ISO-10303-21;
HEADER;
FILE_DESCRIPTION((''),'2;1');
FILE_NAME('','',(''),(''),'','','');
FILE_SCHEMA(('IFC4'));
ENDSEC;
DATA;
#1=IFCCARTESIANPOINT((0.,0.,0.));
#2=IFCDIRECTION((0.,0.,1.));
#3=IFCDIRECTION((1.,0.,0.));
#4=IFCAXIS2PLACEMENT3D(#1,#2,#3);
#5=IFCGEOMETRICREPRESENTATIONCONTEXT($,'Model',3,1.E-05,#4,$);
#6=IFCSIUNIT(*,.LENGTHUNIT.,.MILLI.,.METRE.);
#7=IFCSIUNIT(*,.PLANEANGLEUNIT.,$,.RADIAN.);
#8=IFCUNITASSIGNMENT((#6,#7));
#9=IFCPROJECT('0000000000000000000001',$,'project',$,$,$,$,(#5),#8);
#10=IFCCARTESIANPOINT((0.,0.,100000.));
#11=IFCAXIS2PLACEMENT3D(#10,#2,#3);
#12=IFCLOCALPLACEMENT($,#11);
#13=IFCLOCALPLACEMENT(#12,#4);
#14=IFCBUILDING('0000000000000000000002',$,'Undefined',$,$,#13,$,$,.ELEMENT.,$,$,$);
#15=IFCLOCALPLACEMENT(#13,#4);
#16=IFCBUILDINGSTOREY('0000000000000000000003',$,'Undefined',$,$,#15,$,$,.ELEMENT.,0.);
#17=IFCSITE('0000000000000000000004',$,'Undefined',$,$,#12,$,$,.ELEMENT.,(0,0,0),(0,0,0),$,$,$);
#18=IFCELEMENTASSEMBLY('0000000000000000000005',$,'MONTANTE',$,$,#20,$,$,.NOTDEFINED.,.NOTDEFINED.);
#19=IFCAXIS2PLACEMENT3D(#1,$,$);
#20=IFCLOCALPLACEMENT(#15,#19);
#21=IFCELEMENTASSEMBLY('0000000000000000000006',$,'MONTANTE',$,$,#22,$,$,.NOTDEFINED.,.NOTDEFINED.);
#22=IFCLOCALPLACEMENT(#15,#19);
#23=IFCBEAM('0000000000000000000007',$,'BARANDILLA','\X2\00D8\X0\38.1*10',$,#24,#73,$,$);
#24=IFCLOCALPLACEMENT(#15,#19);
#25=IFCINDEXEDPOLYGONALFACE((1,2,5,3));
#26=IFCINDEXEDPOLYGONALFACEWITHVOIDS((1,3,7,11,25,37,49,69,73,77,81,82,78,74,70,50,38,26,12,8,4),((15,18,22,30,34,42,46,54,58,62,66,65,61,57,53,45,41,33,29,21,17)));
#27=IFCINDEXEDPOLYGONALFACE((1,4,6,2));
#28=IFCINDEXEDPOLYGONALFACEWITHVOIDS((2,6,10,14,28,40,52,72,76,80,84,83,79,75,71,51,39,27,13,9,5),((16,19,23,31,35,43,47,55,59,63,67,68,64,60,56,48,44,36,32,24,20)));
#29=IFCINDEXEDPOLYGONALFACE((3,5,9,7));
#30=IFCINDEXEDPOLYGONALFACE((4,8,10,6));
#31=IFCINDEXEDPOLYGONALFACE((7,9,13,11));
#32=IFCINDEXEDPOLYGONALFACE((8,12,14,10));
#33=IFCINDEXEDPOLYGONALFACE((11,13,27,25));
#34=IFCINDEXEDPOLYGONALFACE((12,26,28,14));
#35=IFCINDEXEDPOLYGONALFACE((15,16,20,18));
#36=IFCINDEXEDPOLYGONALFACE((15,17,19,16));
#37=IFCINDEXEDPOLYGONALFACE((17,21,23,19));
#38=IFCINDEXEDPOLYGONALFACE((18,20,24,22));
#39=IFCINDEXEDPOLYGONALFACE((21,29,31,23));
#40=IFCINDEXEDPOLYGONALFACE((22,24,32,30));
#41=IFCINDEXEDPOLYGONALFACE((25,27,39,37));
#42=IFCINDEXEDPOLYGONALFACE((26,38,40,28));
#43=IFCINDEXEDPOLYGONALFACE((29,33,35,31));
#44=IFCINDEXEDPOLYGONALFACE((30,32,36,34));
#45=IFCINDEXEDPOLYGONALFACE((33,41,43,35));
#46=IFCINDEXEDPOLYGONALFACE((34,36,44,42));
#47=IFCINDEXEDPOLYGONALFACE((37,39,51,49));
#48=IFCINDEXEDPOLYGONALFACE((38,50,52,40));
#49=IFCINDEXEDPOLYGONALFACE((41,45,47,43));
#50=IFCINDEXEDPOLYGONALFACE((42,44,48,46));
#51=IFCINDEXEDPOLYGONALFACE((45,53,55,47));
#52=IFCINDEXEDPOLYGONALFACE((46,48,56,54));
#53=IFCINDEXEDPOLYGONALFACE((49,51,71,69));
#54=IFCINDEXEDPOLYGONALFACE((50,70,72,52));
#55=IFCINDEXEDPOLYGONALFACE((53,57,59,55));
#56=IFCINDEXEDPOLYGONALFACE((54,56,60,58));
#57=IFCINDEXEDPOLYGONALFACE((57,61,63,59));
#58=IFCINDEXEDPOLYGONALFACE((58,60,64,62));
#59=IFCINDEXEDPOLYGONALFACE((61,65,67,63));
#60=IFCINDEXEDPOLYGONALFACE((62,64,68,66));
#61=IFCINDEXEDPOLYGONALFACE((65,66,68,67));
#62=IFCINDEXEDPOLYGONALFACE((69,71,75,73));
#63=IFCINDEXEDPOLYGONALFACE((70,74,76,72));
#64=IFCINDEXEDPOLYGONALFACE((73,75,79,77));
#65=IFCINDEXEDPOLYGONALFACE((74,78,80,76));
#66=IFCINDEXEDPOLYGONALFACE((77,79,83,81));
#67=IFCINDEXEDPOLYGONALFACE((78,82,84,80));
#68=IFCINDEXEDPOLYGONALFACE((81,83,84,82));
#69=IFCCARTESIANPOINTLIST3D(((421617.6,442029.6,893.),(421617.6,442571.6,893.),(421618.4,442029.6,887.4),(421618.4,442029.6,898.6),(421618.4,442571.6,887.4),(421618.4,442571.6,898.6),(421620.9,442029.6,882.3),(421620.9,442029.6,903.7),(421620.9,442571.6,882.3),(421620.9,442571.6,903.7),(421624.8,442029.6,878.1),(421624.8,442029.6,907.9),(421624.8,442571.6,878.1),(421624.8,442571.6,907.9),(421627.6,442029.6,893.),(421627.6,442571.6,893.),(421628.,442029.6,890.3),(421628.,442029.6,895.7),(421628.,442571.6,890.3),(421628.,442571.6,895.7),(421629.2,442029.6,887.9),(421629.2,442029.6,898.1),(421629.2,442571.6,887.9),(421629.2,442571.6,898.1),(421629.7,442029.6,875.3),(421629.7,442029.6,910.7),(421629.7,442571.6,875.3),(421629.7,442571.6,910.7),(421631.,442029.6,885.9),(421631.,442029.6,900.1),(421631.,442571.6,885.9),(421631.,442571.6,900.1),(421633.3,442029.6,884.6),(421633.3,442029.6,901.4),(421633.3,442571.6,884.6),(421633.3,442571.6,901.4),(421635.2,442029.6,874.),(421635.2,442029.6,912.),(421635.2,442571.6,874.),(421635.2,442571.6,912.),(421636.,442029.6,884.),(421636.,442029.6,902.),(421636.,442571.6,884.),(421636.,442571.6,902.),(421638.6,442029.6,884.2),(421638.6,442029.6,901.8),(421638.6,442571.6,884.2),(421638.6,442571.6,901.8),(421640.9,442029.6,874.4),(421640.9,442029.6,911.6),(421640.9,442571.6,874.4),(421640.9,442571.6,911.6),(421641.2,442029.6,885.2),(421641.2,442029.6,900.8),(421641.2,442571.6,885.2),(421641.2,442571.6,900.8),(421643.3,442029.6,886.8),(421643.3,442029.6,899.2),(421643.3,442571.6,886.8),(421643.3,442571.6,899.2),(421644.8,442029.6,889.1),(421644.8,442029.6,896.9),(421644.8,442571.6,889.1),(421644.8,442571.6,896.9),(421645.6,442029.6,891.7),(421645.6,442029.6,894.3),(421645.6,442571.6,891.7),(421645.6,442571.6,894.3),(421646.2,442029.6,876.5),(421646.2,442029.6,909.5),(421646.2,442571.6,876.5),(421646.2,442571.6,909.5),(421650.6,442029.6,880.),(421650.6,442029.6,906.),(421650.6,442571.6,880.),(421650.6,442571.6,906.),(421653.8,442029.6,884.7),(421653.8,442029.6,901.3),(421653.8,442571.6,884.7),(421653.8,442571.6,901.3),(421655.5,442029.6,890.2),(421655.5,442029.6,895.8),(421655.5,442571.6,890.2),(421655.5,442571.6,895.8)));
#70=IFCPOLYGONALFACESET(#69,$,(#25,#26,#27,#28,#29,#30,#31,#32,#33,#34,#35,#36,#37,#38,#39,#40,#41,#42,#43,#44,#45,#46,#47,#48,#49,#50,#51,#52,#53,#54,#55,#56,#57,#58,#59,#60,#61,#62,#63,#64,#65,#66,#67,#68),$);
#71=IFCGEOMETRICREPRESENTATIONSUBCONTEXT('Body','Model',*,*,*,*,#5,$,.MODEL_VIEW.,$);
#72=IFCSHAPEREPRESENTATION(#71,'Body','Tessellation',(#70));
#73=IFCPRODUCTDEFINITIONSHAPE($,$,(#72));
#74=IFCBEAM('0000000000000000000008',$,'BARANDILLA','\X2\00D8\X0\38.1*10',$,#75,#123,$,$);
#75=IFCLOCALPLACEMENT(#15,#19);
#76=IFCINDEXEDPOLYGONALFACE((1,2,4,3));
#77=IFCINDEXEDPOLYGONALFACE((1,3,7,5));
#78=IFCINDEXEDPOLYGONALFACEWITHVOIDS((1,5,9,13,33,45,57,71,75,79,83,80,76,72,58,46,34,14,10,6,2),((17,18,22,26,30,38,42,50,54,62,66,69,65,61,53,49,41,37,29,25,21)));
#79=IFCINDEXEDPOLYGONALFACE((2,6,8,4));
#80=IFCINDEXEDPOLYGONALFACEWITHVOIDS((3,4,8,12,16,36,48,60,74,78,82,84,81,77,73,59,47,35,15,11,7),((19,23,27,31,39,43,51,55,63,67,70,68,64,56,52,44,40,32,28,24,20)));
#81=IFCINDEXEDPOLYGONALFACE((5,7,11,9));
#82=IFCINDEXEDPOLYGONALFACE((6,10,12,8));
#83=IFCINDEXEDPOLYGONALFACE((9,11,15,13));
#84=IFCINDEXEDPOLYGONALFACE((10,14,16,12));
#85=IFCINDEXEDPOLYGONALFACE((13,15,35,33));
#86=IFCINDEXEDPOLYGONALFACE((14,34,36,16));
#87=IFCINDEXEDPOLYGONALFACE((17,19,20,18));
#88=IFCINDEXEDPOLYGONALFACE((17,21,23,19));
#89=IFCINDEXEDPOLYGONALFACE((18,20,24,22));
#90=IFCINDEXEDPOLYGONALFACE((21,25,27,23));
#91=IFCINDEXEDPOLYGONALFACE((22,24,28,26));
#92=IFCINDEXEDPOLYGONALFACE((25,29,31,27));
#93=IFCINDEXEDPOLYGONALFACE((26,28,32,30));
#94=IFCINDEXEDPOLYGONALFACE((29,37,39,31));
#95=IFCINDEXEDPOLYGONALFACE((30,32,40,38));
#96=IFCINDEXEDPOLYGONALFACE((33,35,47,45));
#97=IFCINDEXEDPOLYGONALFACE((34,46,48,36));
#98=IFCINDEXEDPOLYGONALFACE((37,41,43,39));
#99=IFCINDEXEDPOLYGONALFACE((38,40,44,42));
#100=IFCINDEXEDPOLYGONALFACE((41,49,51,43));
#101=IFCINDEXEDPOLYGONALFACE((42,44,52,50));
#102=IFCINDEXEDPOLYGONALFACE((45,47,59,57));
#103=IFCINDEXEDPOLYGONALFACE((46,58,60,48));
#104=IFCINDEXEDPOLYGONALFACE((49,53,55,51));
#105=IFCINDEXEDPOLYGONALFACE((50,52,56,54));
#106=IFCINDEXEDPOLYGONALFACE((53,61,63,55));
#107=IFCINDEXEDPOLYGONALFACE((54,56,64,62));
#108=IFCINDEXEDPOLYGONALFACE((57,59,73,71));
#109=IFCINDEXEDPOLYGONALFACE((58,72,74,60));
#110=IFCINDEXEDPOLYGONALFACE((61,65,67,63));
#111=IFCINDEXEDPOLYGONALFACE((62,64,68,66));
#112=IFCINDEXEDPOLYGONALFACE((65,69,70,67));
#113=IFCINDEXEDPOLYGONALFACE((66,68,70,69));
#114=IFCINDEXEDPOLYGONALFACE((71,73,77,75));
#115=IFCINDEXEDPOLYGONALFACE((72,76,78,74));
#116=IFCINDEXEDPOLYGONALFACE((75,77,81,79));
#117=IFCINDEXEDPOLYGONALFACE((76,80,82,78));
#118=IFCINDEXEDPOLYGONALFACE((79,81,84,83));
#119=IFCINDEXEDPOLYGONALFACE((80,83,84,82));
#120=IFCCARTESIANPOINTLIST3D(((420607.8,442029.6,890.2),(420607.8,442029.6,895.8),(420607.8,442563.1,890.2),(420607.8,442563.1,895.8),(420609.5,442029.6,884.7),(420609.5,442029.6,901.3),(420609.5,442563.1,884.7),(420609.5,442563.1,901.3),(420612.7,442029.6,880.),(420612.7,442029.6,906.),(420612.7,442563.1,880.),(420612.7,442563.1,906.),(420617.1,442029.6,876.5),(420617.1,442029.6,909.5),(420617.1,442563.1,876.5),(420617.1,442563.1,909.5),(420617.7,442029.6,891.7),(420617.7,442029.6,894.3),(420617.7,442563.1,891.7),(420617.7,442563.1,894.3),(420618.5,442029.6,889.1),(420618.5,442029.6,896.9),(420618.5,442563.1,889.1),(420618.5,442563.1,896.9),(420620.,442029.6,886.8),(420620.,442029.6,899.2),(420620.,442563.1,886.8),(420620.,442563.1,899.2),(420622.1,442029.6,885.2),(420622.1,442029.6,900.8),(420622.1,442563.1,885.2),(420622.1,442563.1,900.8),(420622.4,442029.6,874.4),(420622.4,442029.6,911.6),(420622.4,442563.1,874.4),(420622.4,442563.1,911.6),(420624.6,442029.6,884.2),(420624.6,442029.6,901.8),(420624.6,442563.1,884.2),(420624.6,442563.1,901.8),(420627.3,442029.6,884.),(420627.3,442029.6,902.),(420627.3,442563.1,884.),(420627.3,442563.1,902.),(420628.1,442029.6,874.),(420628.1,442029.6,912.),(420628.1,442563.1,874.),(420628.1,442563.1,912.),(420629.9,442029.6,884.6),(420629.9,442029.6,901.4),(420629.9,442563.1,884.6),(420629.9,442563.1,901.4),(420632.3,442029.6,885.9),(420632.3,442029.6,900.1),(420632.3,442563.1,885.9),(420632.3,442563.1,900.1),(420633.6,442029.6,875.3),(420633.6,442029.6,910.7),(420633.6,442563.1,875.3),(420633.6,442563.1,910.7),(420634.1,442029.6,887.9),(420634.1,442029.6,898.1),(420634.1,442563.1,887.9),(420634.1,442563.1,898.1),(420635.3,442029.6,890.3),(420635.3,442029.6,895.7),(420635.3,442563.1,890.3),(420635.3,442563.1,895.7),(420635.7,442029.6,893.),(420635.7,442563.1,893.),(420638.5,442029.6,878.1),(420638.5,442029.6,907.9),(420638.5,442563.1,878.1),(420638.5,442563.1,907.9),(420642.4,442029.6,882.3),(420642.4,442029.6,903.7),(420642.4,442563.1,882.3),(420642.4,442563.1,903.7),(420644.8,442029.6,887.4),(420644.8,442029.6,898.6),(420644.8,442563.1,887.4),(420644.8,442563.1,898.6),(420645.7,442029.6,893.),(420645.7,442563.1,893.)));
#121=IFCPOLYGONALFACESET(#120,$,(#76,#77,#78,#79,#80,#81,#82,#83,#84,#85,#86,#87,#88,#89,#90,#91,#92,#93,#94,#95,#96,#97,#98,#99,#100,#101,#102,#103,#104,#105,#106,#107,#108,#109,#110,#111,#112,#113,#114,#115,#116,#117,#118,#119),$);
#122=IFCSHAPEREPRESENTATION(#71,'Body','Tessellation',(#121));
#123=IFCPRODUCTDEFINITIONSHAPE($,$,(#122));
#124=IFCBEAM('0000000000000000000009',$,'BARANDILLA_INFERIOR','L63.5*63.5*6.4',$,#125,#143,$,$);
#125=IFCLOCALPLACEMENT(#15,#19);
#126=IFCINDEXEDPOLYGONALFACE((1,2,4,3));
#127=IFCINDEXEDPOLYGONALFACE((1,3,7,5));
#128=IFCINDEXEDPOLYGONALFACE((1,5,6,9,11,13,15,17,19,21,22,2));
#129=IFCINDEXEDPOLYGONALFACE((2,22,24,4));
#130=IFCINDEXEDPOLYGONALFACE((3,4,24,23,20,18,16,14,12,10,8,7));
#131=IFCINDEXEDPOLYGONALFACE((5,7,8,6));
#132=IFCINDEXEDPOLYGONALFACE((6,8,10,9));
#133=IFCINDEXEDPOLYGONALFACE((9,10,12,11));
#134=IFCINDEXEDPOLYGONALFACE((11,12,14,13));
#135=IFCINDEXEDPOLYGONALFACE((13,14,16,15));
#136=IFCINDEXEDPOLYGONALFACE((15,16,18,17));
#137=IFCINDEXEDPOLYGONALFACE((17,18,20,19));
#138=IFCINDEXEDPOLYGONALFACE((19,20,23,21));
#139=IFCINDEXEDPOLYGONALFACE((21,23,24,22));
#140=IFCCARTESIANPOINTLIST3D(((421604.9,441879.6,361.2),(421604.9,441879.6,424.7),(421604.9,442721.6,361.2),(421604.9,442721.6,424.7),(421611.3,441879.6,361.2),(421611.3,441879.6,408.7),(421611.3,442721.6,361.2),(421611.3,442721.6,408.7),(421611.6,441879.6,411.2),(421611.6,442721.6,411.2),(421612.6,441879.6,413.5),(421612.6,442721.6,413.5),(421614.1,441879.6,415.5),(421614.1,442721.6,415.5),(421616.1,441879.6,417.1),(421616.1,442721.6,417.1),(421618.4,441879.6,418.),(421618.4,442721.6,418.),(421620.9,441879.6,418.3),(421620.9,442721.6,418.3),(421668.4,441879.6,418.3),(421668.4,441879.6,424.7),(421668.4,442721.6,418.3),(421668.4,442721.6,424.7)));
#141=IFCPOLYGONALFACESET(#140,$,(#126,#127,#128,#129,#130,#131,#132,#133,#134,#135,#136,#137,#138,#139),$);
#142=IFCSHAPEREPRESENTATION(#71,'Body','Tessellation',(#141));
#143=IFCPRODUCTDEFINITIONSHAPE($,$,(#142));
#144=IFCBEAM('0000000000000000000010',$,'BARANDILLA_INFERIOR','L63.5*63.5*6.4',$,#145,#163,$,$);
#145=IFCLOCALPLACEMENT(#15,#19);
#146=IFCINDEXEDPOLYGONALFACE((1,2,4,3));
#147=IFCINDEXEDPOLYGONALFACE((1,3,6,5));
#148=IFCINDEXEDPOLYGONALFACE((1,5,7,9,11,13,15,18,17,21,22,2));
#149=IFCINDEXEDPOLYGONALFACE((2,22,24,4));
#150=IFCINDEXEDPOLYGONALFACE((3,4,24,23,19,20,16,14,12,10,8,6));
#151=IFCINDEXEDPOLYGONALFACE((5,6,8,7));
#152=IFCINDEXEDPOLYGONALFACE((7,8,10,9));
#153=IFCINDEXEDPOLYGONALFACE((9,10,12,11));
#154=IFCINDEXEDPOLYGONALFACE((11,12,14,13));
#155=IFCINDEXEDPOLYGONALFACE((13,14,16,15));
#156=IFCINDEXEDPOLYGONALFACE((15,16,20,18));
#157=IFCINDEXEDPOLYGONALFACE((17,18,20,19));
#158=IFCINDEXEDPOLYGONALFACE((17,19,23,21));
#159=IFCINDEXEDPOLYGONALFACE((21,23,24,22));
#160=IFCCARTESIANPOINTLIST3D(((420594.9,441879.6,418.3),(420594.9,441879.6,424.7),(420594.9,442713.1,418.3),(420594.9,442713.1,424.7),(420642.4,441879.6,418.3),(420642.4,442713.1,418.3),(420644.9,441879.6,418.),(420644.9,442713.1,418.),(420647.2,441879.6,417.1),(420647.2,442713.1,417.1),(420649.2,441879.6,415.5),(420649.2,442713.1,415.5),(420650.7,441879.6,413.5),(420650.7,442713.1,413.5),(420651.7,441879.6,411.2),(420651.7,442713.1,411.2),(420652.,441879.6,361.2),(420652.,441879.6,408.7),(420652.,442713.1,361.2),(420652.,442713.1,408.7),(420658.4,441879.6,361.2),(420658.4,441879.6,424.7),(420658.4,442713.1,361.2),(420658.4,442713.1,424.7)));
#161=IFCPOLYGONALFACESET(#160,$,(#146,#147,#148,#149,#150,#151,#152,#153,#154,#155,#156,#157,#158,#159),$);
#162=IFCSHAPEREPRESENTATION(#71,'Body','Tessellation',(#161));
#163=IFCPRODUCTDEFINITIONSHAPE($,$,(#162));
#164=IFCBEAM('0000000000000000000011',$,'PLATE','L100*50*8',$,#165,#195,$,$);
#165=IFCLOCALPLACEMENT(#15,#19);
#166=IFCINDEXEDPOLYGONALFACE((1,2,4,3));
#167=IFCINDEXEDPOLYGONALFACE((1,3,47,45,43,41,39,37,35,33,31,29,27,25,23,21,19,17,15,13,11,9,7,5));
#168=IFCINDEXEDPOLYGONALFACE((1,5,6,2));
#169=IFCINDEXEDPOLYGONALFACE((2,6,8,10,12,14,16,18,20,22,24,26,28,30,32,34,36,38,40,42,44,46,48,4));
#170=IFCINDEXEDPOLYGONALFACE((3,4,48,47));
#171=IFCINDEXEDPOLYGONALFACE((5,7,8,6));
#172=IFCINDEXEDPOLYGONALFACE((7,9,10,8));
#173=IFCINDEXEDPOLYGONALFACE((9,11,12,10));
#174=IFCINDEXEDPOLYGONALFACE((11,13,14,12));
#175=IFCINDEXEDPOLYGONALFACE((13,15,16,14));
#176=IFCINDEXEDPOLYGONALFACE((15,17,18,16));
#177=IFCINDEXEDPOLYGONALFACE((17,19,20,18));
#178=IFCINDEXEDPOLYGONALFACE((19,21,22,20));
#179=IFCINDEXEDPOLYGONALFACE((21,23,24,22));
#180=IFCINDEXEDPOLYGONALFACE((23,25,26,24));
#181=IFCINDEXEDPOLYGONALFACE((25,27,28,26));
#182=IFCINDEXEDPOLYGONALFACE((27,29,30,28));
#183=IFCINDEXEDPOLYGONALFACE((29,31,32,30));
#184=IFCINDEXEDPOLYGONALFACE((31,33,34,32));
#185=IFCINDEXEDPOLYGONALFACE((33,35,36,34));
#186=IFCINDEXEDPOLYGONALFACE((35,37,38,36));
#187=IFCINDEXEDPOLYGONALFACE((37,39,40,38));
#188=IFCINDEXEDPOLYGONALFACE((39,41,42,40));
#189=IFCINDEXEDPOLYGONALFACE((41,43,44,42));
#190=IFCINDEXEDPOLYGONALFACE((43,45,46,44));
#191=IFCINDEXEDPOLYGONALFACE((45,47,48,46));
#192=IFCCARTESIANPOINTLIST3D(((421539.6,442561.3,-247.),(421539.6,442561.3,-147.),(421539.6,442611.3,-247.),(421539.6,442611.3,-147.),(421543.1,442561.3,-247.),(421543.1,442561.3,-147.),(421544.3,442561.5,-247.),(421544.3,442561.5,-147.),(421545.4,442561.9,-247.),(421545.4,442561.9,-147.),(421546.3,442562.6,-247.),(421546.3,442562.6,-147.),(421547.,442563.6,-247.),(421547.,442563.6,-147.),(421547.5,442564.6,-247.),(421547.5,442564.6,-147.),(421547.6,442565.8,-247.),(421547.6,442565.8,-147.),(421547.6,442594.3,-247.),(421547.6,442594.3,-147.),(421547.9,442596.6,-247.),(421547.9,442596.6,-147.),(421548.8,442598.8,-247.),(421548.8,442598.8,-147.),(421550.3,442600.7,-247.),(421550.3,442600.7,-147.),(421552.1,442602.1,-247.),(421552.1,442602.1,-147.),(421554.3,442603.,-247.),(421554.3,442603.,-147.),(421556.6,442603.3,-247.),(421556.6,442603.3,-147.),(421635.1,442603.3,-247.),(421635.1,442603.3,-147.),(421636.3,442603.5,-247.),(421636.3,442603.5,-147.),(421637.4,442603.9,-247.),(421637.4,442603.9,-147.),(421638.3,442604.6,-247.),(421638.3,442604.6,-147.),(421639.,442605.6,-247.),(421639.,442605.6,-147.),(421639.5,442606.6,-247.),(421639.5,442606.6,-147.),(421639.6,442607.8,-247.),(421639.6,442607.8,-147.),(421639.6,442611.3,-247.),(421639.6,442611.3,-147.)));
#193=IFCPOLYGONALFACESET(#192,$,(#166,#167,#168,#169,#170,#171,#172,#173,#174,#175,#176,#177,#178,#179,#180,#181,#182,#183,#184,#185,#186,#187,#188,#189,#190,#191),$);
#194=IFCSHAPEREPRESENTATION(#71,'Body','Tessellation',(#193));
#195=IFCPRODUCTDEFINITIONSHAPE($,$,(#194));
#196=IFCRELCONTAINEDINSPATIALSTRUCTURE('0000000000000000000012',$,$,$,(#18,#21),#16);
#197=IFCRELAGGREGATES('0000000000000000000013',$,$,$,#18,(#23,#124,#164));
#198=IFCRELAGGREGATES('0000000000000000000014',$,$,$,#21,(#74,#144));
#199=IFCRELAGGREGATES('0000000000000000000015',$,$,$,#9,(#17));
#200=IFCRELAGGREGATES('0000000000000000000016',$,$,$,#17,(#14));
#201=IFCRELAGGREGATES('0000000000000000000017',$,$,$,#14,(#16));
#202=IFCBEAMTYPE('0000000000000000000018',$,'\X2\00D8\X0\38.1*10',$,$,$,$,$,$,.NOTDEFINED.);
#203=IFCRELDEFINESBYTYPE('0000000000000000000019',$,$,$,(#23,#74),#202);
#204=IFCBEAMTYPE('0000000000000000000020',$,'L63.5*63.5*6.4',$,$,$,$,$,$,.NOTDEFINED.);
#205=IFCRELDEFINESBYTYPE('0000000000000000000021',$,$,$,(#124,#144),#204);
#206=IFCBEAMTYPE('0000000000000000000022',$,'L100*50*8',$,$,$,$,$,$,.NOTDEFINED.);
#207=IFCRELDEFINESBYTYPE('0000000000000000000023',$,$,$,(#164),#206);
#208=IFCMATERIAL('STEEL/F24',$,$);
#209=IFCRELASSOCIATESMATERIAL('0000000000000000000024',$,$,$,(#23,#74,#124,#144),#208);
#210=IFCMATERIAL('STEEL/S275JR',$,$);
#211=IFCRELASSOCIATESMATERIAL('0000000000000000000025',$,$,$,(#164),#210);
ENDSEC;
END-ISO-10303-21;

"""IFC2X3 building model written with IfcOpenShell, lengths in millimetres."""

from ifc_helpers import new_model, si_unit, frame, origin_with_axes, origin_2d_with_axis, place, context, subcontext, project, spatial, hollow_circle, l_section, extrude, clip, halfspace, material, type_object, element, aggregate, save


model = new_model("IFC2X3")

# Units and contexts
model_context = context("Model", 3, precision=1e-05, world=origin_with_axes())
body_context = subcontext(model_context, "Body", "Model", "MODEL_VIEW")
ifc_project = project(units=[si_unit("LENGTHUNIT", "METRE", prefix="MILLI"), si_unit("PLANEANGLEUNIT", "RADIAN")], contexts=[model_context])

# Site, building, storey
site_placement = place(None, frame((0.0, 0.0, 100000.0), z_axis=(0.0, 0.0, 1.0), x_axis=(1.0, 0.0, 0.0)))
site = spatial("IfcSite", under=ifc_project, at=site_placement, Name="Undefined", CompositionType="ELEMENT", RefLatitude=(0, 0, 0), RefLongitude=(0, 0, 0))
building_placement = place(site_placement, origin_with_axes())
building = spatial("IfcBuilding", under=site, at=building_placement, Name="Undefined", CompositionType="ELEMENT")
storey_placement = place(building_placement, origin_with_axes())
storey = spatial("IfcBuildingStorey", under=building, at=storey_placement, Name="Undefined", CompositionType="ELEMENT", Elevation=0.0)

# Element assembly
assembly_1_placement = place(storey_placement, origin_with_axes())
assembly_1 = element("IfcElementAssembly", 1, at=assembly_1_placement, inside=storey, Name="MONTANTE", AssemblyPlace="NOTDEFINED", PredefinedType="NOTDEFINED")
ifc_material_1 = material(Name="STEEL/F24")

# Element assembly
assembly_2_placement = place(storey_placement, origin_with_axes())
assembly_2 = element("IfcElementAssembly", 2, at=assembly_2_placement, inside=storey, Name="MONTANTE", AssemblyPlace="NOTDEFINED", PredefinedType="NOTDEFINED")

# Beams
beam_type_1 = type_object("IfcBeamType", Name="Ø38.1*10", PredefinedType="NOTDEFINED")
beam_1_placement = place(assembly_1_placement, frame((421636.6, 442029.6, 893.0), z_axis=(0.0, 0.0, -1.0), x_axis=(0.0, 1.0, 0.0)))
beam_1 = element("IfcBeam", 3, at=beam_1_placement, type_object=beam_type_1, material=ifc_material_1, Name="BARANDILLA", Description="Ø38.1*10", context=body_context, shape_type="Clipping", body=[
    clip(clip(extrude(hollow_circle(Radius=19.1, WallThickness=10.0, at=origin_2d_with_axis()), frame((541.9, 0.0, 0.0), z_axis=(-1.0, 0.0, 0.0), x_axis=(0.0, -1.0, 0.0)), (0.0, 0.0, 1.0), 542.0), halfspace(frame((541.9, 0.0, 0.0), z_axis=(1.0, 0.0, 0.0), x_axis=(0.0, -1.0, 0.0)), False)), halfspace(frame((0.0, 0.0, 0.0), z_axis=(1.0, 0.0, 0.0), x_axis=(0.0, -1.0, 0.0)), True)),
])
beam_2_placement = place(assembly_2_placement, frame((420626.6, 442563.1, 893.0), z_axis=(0.0, 0.0, -1.0), x_axis=(0.0, -1.0, 0.0)))
beam_2 = element("IfcBeam", 4, at=beam_2_placement, type_object=beam_type_1, material=ifc_material_1, Name="BARANDILLA", Description="Ø38.1*10", context=body_context, shape_type="Clipping", body=[
    clip(clip(extrude(hollow_circle(Radius=19.1, WallThickness=10.0, at=origin_2d_with_axis()), frame((533.5, 0.0, 0.0), z_axis=(-1.0, 0.0, 0.0), x_axis=(0.0, -1.0, 0.0)), (0.0, 0.0, 1.0), 533.5), halfspace(frame((533.5, 0.0, 0.0), z_axis=(1.0, 0.0, 0.0), x_axis=(0.0, -1.0, 0.0)), False)), halfspace(frame((0.0, 0.0, 0.0), z_axis=(1.0, 0.0, 0.0), x_axis=(0.0, -1.0, 0.0)), True)),
])
beam_type_2 = type_object("IfcBeamType", Name="L63.5*63.5*6.4", PredefinedType="NOTDEFINED")
beam_3_placement = place(assembly_1_placement, frame((421636.6, 441879.6, 393.0), z_axis=(1.0, 0.0, 0.0), x_axis=(0.0, 1.0, 0.0)))
beam_3 = element("IfcBeam", 5, at=beam_3_placement, type_object=beam_type_2, material=ifc_material_1, Name="BARANDILLA_INFERIOR", Description="L63.5*63.5*6.4", context=body_context, shape_type="SweptSolid", body=[
    extrude(l_section(Depth=63.5, Width=63.5, Thickness=6.4, FilletRadius=9.6, at=origin_2d_with_axis()), frame((841.9, 0.0, 0.0), z_axis=(-1.0, 0.0, 0.0), x_axis=(0.0, -1.0, 0.0)), (0.0, 0.0, 1.0), 842.0),
])
beam_4_placement = place(assembly_2_placement, frame((420626.6, 442713.1, 393.0), z_axis=(-1.0, 0.0, 0.0), x_axis=(0.0, -1.0, 0.0)))
beam_4 = element("IfcBeam", 6, at=beam_4_placement, type_object=beam_type_2, material=ifc_material_1, Name="BARANDILLA_INFERIOR", Description="L63.5*63.5*6.4", context=body_context, shape_type="SweptSolid", body=[
    extrude(l_section(Depth=63.5, Width=63.5, Thickness=6.4, FilletRadius=9.6, at=origin_2d_with_axis()), frame((833.5, 0.0, 0.0), z_axis=(-1.0, 0.0, 0.0), x_axis=(0.0, -1.0, 0.0)), (0.0, 0.0, 1.0), 833.5),
])
ifc_material_2 = material(Name="STEEL/S275JR")
beam_type_3 = type_object("IfcBeamType", Name="L100*50*8", PredefinedType="NOTDEFINED")
beam_5_placement = place(assembly_1_placement, frame((421589.6, 442586.3, -147.0), z_axis=(1.0, 0.0, 0.0), x_axis=(0.0, 0.0, -1.0)))
beam_5 = element("IfcBeam", 7, at=beam_5_placement, type_object=beam_type_3, material=ifc_material_2, Name="PLATE", Description="L100*50*8", context=body_context, shape_type="SweptSolid", body=[
    extrude(l_section(Depth=100.0, Width=50.0, Thickness=8.0, FilletRadius=9.0, EdgeRadius=4.5, at=origin_2d_with_axis()), frame((100.0, 0.0, 0.0), z_axis=(-1.0, 0.0, 0.0), x_axis=(0.0, -1.0, 0.0)), (0.0, 0.0, 1.0), 100.0),
])

aggregate(assembly_1, [beam_1, beam_3, beam_5])
aggregate(assembly_2, [beam_2, beam_4])

save(model, "model.ifc")
